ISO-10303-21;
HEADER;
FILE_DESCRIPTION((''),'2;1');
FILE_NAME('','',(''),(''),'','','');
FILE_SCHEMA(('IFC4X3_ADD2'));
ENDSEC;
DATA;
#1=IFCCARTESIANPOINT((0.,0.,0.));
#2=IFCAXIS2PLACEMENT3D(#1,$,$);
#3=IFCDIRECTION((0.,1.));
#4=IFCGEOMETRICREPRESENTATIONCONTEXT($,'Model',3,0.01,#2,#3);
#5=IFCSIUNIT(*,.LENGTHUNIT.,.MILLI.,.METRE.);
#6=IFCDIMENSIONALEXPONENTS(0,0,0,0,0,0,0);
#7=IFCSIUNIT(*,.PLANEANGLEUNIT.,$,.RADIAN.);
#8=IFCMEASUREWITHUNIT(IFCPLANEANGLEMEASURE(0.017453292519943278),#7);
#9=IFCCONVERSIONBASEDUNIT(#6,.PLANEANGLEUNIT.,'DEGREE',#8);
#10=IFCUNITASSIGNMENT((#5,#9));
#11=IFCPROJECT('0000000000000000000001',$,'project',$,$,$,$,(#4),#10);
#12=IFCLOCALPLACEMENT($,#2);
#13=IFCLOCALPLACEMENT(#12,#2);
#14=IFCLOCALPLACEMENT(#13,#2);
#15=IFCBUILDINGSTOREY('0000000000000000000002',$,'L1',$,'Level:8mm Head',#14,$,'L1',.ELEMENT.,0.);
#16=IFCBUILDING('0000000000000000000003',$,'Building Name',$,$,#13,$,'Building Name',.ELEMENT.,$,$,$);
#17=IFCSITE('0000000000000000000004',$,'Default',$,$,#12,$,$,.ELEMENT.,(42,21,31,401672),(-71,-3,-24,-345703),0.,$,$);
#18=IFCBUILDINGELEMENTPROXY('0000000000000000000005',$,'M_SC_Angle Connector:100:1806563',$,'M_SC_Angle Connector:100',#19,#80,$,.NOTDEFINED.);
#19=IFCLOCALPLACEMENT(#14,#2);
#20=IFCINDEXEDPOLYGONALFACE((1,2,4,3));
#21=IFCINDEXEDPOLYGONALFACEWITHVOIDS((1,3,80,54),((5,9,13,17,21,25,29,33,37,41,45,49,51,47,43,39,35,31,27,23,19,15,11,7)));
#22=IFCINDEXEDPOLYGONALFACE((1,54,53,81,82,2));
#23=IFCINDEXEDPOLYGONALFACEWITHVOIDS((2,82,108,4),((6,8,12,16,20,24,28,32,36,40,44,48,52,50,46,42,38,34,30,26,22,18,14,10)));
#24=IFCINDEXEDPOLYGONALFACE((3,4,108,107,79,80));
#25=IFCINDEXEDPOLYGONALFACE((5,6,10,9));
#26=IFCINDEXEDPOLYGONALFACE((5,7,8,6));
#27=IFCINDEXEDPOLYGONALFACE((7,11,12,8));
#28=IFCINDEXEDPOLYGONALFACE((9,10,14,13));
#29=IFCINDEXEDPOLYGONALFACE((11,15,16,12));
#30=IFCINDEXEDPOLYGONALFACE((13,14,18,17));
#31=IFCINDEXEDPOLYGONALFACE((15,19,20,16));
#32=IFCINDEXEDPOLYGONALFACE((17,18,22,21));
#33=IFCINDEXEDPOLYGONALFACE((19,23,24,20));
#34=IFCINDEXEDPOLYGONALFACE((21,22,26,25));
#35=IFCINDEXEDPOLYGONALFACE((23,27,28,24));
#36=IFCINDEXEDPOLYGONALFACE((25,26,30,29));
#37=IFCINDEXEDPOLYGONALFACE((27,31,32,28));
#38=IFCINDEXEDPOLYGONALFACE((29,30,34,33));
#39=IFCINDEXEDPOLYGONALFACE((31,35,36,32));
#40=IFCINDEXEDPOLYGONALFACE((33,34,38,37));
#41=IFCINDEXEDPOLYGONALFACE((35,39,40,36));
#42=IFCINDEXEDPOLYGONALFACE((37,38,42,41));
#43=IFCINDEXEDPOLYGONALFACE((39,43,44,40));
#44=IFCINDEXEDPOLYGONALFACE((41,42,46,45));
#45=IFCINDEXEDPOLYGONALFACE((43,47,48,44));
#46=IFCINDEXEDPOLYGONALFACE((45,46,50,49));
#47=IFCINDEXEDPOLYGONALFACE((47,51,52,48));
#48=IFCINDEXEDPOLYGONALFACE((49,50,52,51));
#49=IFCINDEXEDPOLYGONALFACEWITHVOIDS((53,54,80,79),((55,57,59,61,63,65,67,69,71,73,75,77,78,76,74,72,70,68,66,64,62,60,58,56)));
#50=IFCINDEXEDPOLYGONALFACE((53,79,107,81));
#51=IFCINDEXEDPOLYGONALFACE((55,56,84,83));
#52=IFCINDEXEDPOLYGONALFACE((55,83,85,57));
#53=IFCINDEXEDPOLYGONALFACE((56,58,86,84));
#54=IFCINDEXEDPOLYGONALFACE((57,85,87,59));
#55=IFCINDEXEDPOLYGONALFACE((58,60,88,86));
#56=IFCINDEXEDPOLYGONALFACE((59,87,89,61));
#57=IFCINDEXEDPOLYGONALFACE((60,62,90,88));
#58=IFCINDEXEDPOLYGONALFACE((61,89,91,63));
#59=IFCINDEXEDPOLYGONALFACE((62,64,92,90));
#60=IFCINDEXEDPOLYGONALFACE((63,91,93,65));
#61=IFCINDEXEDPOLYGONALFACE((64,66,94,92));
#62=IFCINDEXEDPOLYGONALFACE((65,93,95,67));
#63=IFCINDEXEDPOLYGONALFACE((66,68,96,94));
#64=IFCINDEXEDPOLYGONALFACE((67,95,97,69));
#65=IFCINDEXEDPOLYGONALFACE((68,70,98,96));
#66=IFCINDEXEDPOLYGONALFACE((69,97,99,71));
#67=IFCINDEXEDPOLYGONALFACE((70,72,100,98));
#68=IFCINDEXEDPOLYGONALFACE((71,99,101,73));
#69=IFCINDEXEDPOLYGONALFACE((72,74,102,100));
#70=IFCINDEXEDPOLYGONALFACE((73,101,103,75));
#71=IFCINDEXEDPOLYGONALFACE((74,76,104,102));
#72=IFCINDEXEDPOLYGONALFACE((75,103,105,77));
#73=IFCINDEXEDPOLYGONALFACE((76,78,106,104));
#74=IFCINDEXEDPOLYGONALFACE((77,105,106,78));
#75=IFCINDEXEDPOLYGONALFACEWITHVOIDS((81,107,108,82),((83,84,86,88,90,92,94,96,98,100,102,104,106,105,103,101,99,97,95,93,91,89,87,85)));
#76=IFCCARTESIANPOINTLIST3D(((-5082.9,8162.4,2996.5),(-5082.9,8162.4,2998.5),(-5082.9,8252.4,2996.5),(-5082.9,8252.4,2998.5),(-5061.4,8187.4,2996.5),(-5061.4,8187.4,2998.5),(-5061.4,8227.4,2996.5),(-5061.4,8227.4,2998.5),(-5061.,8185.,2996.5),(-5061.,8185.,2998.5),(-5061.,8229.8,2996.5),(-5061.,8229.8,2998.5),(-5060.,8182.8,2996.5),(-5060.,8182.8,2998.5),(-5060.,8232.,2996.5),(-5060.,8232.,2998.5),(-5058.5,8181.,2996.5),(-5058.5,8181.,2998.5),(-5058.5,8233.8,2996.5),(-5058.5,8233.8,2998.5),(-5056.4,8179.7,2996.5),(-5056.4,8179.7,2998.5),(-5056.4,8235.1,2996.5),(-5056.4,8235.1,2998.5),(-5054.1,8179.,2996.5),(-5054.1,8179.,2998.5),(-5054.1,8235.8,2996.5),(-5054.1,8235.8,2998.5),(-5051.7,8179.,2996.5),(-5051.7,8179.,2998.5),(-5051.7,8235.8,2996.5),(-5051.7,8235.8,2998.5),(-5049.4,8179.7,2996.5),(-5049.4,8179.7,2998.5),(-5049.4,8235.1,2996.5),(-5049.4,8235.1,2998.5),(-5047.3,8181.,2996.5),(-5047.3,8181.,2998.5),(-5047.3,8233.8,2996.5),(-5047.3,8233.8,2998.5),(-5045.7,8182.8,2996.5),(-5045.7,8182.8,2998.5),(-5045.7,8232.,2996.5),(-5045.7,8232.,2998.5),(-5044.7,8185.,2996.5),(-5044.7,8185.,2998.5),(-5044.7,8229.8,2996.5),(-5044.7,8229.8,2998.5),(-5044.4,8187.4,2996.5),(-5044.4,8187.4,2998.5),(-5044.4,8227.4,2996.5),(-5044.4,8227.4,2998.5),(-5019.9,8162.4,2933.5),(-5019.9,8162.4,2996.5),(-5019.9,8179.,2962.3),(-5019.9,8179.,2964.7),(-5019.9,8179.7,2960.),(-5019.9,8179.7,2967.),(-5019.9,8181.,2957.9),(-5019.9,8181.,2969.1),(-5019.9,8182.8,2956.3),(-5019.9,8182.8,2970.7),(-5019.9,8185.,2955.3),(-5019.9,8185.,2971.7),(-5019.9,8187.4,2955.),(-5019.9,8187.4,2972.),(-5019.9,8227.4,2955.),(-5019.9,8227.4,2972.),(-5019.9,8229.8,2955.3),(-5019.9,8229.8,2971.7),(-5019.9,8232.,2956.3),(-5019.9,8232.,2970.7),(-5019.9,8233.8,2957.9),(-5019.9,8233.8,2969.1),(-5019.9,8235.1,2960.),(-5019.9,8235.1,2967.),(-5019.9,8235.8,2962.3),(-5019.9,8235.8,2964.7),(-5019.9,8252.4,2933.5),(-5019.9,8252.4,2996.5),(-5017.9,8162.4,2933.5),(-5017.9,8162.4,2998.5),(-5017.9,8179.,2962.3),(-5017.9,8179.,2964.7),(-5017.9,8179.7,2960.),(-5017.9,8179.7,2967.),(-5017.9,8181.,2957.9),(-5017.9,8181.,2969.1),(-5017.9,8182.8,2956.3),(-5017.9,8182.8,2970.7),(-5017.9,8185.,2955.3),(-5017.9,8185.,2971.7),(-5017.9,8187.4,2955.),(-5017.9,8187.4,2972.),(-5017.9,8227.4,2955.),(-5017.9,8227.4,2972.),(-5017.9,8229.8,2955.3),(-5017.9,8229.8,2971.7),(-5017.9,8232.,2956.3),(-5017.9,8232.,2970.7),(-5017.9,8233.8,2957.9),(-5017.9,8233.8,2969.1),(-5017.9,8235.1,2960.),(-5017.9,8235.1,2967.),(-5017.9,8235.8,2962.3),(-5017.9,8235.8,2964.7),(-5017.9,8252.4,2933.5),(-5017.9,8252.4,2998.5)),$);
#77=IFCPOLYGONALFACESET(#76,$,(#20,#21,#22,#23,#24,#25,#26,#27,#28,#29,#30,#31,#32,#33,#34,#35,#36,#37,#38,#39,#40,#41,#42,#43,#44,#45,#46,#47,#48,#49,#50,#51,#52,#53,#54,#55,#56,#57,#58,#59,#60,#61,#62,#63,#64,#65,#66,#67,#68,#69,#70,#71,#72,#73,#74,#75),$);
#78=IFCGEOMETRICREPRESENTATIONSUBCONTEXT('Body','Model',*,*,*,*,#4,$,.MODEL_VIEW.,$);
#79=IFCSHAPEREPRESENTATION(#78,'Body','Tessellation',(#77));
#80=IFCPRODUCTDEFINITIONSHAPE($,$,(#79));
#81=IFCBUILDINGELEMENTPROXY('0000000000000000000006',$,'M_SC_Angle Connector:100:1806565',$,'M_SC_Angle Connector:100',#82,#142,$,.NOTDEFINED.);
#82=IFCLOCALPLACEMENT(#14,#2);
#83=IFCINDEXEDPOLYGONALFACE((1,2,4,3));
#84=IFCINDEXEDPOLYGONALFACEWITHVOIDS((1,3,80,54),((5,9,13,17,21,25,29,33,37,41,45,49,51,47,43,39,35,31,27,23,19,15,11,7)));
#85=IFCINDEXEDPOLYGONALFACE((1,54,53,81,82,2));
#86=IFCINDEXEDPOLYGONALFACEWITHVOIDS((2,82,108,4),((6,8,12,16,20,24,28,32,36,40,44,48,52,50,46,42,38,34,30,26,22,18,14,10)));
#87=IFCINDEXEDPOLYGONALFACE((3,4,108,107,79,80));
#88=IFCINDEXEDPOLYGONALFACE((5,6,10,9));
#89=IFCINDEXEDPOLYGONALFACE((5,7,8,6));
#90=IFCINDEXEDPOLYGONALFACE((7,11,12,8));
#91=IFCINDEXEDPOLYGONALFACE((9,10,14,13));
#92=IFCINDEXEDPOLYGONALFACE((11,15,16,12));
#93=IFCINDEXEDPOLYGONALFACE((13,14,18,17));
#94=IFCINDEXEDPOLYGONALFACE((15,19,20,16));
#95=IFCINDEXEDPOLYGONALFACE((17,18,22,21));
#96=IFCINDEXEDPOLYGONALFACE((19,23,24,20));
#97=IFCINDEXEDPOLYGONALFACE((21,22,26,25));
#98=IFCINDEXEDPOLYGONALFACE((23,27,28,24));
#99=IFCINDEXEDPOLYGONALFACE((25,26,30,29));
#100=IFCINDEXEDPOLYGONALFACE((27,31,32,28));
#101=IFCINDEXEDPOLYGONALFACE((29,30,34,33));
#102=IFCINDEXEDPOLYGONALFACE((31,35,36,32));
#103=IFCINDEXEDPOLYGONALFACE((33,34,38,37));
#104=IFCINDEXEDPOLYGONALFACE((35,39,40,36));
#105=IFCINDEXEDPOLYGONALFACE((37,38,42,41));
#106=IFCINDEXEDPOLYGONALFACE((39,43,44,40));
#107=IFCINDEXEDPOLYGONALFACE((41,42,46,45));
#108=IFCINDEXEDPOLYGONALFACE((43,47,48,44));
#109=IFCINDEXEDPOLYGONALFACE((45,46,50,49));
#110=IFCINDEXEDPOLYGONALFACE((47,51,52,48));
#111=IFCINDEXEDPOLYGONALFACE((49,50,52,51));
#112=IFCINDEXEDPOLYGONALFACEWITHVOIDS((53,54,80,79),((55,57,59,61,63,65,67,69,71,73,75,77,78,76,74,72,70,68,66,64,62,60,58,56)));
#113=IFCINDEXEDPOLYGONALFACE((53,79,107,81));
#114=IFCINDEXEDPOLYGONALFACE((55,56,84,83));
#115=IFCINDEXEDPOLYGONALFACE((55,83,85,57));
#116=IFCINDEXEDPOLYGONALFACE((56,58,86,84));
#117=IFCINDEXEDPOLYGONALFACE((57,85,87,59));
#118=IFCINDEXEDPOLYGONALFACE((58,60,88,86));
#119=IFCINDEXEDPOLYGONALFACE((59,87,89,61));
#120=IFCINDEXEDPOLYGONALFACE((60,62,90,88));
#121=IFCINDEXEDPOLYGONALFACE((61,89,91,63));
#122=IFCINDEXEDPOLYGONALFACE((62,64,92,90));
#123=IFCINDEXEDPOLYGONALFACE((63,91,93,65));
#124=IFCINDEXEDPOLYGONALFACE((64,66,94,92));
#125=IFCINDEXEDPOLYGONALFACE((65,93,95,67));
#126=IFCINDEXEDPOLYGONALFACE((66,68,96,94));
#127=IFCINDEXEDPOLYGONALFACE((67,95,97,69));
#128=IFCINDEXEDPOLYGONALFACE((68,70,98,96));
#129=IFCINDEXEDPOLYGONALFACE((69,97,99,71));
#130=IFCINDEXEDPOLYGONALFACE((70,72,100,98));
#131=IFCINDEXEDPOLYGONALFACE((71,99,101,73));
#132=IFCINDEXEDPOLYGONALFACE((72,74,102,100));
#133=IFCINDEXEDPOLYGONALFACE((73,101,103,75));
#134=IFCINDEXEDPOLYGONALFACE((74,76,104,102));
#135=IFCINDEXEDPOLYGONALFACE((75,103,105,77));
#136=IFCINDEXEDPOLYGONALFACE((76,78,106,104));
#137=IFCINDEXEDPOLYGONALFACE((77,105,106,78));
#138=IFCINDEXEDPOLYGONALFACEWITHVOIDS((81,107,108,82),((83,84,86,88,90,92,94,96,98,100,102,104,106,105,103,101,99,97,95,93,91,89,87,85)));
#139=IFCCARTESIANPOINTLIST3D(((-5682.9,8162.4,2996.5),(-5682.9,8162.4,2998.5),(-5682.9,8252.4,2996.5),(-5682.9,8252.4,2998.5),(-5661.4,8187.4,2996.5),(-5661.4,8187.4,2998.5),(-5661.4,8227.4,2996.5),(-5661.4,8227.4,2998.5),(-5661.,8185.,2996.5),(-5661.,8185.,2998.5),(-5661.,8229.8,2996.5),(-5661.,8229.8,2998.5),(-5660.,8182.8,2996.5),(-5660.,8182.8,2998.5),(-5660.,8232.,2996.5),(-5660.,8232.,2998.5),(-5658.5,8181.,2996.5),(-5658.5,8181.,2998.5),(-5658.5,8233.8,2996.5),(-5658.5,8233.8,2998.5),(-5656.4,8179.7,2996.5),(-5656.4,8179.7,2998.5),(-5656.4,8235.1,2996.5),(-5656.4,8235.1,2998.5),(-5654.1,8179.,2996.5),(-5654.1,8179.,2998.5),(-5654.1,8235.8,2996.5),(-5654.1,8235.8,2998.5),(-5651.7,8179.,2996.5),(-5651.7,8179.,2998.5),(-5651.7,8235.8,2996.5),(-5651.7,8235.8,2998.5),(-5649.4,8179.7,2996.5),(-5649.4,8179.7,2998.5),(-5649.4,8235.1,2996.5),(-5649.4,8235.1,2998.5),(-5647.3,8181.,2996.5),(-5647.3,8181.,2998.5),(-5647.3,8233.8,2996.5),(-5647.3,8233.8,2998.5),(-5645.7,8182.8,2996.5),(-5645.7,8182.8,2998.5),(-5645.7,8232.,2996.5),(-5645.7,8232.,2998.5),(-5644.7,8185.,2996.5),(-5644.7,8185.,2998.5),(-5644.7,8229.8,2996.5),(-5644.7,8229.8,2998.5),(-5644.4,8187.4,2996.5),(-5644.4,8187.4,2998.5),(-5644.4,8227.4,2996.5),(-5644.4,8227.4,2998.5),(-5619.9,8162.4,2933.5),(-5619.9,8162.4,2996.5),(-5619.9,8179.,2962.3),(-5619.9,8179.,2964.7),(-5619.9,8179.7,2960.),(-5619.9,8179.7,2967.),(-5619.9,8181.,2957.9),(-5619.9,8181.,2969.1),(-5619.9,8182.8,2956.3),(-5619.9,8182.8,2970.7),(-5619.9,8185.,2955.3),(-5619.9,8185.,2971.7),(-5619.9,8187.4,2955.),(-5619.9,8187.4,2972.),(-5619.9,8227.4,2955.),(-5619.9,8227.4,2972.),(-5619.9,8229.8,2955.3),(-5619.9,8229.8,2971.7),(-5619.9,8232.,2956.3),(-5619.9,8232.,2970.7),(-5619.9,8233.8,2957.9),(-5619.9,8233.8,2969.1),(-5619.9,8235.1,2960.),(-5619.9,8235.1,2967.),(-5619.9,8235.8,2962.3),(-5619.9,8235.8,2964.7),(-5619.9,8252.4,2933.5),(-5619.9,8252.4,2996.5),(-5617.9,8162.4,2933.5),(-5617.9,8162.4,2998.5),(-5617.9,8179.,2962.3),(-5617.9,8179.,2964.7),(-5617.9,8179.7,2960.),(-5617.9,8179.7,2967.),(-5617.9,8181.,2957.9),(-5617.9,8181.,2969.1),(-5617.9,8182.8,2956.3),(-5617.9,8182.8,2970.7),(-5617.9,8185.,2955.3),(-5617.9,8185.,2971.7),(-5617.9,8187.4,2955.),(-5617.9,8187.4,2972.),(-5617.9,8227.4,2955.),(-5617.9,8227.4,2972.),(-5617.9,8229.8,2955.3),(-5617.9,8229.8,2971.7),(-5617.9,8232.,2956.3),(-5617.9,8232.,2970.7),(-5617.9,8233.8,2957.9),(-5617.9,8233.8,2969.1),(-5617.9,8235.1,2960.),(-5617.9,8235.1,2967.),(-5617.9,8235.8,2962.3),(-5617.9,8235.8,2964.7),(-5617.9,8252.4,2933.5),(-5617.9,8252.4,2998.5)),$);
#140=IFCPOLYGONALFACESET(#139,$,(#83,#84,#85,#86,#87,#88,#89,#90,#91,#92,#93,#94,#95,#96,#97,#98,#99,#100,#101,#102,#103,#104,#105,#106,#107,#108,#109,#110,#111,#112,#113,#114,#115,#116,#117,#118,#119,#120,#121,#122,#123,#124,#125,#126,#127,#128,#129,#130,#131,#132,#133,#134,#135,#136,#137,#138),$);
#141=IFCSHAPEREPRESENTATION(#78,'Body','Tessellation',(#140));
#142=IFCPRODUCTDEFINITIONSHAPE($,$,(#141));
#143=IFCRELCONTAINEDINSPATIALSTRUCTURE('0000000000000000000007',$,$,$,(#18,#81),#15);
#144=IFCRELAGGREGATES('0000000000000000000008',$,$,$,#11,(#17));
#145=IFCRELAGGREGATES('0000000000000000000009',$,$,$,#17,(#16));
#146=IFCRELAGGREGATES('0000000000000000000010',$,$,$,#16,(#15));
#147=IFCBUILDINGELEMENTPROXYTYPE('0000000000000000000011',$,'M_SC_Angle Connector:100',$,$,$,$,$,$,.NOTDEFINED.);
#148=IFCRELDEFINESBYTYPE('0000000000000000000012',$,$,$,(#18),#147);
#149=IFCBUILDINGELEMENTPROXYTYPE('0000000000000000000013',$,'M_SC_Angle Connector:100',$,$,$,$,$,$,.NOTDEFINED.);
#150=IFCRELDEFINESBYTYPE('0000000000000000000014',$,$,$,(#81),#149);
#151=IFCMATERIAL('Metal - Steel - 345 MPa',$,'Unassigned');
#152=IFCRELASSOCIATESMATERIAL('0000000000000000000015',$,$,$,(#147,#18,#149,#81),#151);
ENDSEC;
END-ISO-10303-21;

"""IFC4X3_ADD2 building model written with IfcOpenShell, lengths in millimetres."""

from ifc_helpers import new_model, entity, si_unit, converted_unit, direction, frame, frame_2d, origin, place, context, subcontext, project, spatial, polyline, circle_curve, parameter, trimmed, segment, composite_curve, outline, extrude, source, transform, mapped, material, type_object, type_shapes, element, save


model = new_model("IFC4X3_ADD2")

# Units and contexts
model_context = context("Model", 3, precision=0.01, world=origin(), true_north=direction((0.0, 1.0)))
body_context = subcontext(model_context, "Body", "Model", "MODEL_VIEW")
ifc_project = project(units=[si_unit("LENGTHUNIT", "METRE", prefix="MILLI"), converted_unit("PLANEANGLEUNIT", "DEGREE", entity("IfcPlaneAngleMeasure", 0.017453292519943278), si_unit("PLANEANGLEUNIT", "RADIAN"), dimensions=[0, 0, 0, 0, 0, 0, 0])], contexts=[model_context])

# Site, building, storey
site_placement = place(None, origin())
site = spatial("IfcSite", under=ifc_project, at=site_placement, Name="Default", CompositionType="ELEMENT", RefLatitude=(42, 21, 31, 401672), RefLongitude=(-71, -3, -24, -345703), RefElevation=0.0)
building_placement = place(site_placement, origin())
building = spatial("IfcBuilding", under=site, at=building_placement, Name="Building Name", LongName="Building Name", CompositionType="ELEMENT")
storey_placement = place(building_placement, origin())
storey = spatial("IfcBuildingStorey", under=building, at=storey_placement, Name="L1", ObjectType="Level:8mm Head", LongName="L1", CompositionType="ELEMENT", Elevation=0.0)

# Building element proxies, openings
ifc_material_1 = material(Name="Metal - Steel - 345 MPa", Category="Unassigned")
building_element_proxy_type_1 = type_object("IfcBuildingElementProxyType", Name="M_SC_Angle Connector:100", PredefinedType="NOTDEFINED", material=ifc_material_1)
shared_shape_1 = source(origin(), body_context, "Body", "SweptSolid", [
    extrude(outline(polyline([(-42.7, -22.3), (22.3, -22.3), (22.3, 42.7), (20.3, 42.7), (20.3, -20.3), (-42.7, -20.3), (-42.7, -22.3)])), frame((22.3, -45.0, 22.3), z_axis=(0.0, 1.0, 0.0), x_axis=(-1.0, 0.0, 0.0)), (0.0, 0.0, 1.0), 90.0),
])
type_shapes(building_element_proxy_type_1, [shared_shape_1])
proxy_1_placement = place(storey_placement, frame((-5017.9, 8207.4, 2998.5), z_axis=(0.0, 0.0, -1.0), x_axis=(-1.0, 0.0, 0.0)))
proxy_1 = element("IfcBuildingElementProxy", 1, at=proxy_1_placement, inside=storey, type_object=building_element_proxy_type_1, material=ifc_material_1, Name="M_SC_Angle Connector:100:1806563", ObjectType="M_SC_Angle Connector:100", PredefinedType="NOTDEFINED", context=body_context, shape_type="MappedRepresentation", body=[
    mapped(shared_shape_1, transform((0.0, 0.0, 0.0), scale=1.0)),
])
opening_1_placement = place(storey_placement, frame((-5017.9, 8207.4, 2998.5)))
element("IfcOpeningElement", 2, at=opening_1_placement, cuts=proxy_1, PredefinedType="OPENING", context=body_context, shape_type="SweptSolid", body=[
    extrude(outline(composite_curve([segment(trimmed(circle_curve(frame_2d((0.0, 20.0), x_axis=(1.0, 0.0)), 8.5), [parameter(360.0)], [parameter(180.0)], True, "PARAMETER"), True, "CONTINUOUS"), segment(polyline([(-8.5, 20.0), (-8.5, -20.0)]), True, "CONTINUOUS"), segment(trimmed(circle_curve(frame_2d((0.0, -20.0), x_axis=(1.0, 0.0)), 8.5), [parameter(180.0)], [parameter(360.0)], True, "PARAMETER"), True, "CONTINUOUS"), segment(polyline([(8.5, -20.0), (8.5, 20.0)]), True, "CONTINUOUS")], self_intersect=False)), frame((0.0, 0.0, -35.0), z_axis=(-1.0, 0.0, 0.0), x_axis=(0.0, 0.0, -1.0)), (0.0, 0.0, 1.0), 2.0),
])
opening_2_placement = place(storey_placement, frame((-5017.9, 8207.4, 2998.5)))
element("IfcOpeningElement", 3, at=opening_2_placement, cuts=proxy_1, PredefinedType="OPENING", context=body_context, shape_type="SweptSolid", body=[
    extrude(outline(composite_curve([segment(trimmed(circle_curve(frame_2d((0.0, 20.0), x_axis=(1.0, 0.0)), 8.5), [parameter(0.0)], [parameter(180.0)], True, "PARAMETER"), True, "CONTINUOUS"), segment(polyline([(-8.5, 20.0), (-8.5, -20.0)]), True, "CONTINUOUS"), segment(trimmed(circle_curve(frame_2d((0.0, -20.0), x_axis=(1.0, 0.0)), 8.5), [parameter(180.0)], [parameter(0.0)], True, "PARAMETER"), True, "CONTINUOUS"), segment(polyline([(8.5, -20.0), (8.5, 20.0)]), True, "CONTINUOUS")], self_intersect=False)), frame((-35.0, 0.0, -2.0), z_axis=(0.0, 0.0, 1.0), x_axis=(-1.0, 0.0, 0.0)), (0.0, 0.0, 1.0), 2.0),
])
building_element_proxy_type_2 = type_object("IfcBuildingElementProxyType", Name="M_SC_Angle Connector:100", PredefinedType="NOTDEFINED", material=ifc_material_1)
shared_shape_2 = source(origin(), body_context, "Body", "SweptSolid", [
    extrude(outline(polyline([(-42.7, -22.3), (22.3, -22.3), (22.3, 42.7), (20.3, 42.7), (20.3, -20.3), (-42.7, -20.3), (-42.7, -22.3)])), frame((22.3, -45.0, 22.3), z_axis=(0.0, 1.0, 0.0), x_axis=(-1.0, 0.0, 0.0)), (0.0, 0.0, 1.0), 90.0),
])
type_shapes(building_element_proxy_type_2, [shared_shape_2])
proxy_2_placement = place(storey_placement, frame((-5617.9, 8207.4, 2998.5), z_axis=(0.0, 0.0, -1.0), x_axis=(-1.0, 0.0, 0.0)))
proxy_2 = element("IfcBuildingElementProxy", 4, at=proxy_2_placement, inside=storey, type_object=building_element_proxy_type_2, material=ifc_material_1, Name="M_SC_Angle Connector:100:1806565", ObjectType="M_SC_Angle Connector:100", PredefinedType="NOTDEFINED", context=body_context, shape_type="MappedRepresentation", body=[
    mapped(shared_shape_2, transform((0.0, 0.0, 0.0), scale=1.0)),
])
opening_3_placement = place(storey_placement, frame((-5617.9, 8207.4, 2998.5)))
element("IfcOpeningElement", 5, at=opening_3_placement, cuts=proxy_2, PredefinedType="OPENING", context=body_context, shape_type="SweptSolid", body=[
    extrude(outline(composite_curve([segment(trimmed(circle_curve(frame_2d((0.0, -20.0), x_axis=(1.0, 0.0)), 8.5), [parameter(180.0)], [parameter(0.0)], True, "PARAMETER"), True, "CONTINUOUS"), segment(polyline([(8.5, -20.0), (8.5, 20.0)]), True, "CONTINUOUS"), segment(trimmed(circle_curve(frame_2d((0.0, 20.0), x_axis=(1.0, 0.0)), 8.5), [parameter(0.0)], [parameter(180.0)], True, "PARAMETER"), True, "CONTINUOUS"), segment(polyline([(-8.5, 20.0), (-8.5, -20.0)]), True, "CONTINUOUS")], self_intersect=False)), frame((-2.0, 0.0, -35.0), z_axis=(1.0, 0.0, 0.0), x_axis=(0.0, 0.0, -1.0)), (0.0, 0.0, 1.0), 2.0),
])
opening_4_placement = place(storey_placement, frame((-5617.9, 8207.4, 2998.5)))
element("IfcOpeningElement", 6, at=opening_4_placement, cuts=proxy_2, PredefinedType="OPENING", context=body_context, shape_type="SweptSolid", body=[
    extrude(outline(composite_curve([segment(trimmed(circle_curve(frame_2d((0.0, 20.0), x_axis=(1.0, 0.0)), 8.5), [parameter(0.0)], [parameter(180.0)], True, "PARAMETER"), True, "CONTINUOUS"), segment(polyline([(-8.5, 20.0), (-8.5, -20.0)]), True, "CONTINUOUS"), segment(trimmed(circle_curve(frame_2d((0.0, -20.0), x_axis=(1.0, 0.0)), 8.5), [parameter(180.0)], [parameter(0.0)], True, "PARAMETER"), True, "CONTINUOUS"), segment(polyline([(8.5, -20.0), (8.5, 20.0)]), True, "CONTINUOUS")], self_intersect=False)), frame((-35.0, 0.0, -2.0), z_axis=(0.0, 0.0, 1.0), x_axis=(-1.0, 0.0, 0.0)), (0.0, 0.0, 1.0), 2.0),
])

save(model, "model.ifc")
